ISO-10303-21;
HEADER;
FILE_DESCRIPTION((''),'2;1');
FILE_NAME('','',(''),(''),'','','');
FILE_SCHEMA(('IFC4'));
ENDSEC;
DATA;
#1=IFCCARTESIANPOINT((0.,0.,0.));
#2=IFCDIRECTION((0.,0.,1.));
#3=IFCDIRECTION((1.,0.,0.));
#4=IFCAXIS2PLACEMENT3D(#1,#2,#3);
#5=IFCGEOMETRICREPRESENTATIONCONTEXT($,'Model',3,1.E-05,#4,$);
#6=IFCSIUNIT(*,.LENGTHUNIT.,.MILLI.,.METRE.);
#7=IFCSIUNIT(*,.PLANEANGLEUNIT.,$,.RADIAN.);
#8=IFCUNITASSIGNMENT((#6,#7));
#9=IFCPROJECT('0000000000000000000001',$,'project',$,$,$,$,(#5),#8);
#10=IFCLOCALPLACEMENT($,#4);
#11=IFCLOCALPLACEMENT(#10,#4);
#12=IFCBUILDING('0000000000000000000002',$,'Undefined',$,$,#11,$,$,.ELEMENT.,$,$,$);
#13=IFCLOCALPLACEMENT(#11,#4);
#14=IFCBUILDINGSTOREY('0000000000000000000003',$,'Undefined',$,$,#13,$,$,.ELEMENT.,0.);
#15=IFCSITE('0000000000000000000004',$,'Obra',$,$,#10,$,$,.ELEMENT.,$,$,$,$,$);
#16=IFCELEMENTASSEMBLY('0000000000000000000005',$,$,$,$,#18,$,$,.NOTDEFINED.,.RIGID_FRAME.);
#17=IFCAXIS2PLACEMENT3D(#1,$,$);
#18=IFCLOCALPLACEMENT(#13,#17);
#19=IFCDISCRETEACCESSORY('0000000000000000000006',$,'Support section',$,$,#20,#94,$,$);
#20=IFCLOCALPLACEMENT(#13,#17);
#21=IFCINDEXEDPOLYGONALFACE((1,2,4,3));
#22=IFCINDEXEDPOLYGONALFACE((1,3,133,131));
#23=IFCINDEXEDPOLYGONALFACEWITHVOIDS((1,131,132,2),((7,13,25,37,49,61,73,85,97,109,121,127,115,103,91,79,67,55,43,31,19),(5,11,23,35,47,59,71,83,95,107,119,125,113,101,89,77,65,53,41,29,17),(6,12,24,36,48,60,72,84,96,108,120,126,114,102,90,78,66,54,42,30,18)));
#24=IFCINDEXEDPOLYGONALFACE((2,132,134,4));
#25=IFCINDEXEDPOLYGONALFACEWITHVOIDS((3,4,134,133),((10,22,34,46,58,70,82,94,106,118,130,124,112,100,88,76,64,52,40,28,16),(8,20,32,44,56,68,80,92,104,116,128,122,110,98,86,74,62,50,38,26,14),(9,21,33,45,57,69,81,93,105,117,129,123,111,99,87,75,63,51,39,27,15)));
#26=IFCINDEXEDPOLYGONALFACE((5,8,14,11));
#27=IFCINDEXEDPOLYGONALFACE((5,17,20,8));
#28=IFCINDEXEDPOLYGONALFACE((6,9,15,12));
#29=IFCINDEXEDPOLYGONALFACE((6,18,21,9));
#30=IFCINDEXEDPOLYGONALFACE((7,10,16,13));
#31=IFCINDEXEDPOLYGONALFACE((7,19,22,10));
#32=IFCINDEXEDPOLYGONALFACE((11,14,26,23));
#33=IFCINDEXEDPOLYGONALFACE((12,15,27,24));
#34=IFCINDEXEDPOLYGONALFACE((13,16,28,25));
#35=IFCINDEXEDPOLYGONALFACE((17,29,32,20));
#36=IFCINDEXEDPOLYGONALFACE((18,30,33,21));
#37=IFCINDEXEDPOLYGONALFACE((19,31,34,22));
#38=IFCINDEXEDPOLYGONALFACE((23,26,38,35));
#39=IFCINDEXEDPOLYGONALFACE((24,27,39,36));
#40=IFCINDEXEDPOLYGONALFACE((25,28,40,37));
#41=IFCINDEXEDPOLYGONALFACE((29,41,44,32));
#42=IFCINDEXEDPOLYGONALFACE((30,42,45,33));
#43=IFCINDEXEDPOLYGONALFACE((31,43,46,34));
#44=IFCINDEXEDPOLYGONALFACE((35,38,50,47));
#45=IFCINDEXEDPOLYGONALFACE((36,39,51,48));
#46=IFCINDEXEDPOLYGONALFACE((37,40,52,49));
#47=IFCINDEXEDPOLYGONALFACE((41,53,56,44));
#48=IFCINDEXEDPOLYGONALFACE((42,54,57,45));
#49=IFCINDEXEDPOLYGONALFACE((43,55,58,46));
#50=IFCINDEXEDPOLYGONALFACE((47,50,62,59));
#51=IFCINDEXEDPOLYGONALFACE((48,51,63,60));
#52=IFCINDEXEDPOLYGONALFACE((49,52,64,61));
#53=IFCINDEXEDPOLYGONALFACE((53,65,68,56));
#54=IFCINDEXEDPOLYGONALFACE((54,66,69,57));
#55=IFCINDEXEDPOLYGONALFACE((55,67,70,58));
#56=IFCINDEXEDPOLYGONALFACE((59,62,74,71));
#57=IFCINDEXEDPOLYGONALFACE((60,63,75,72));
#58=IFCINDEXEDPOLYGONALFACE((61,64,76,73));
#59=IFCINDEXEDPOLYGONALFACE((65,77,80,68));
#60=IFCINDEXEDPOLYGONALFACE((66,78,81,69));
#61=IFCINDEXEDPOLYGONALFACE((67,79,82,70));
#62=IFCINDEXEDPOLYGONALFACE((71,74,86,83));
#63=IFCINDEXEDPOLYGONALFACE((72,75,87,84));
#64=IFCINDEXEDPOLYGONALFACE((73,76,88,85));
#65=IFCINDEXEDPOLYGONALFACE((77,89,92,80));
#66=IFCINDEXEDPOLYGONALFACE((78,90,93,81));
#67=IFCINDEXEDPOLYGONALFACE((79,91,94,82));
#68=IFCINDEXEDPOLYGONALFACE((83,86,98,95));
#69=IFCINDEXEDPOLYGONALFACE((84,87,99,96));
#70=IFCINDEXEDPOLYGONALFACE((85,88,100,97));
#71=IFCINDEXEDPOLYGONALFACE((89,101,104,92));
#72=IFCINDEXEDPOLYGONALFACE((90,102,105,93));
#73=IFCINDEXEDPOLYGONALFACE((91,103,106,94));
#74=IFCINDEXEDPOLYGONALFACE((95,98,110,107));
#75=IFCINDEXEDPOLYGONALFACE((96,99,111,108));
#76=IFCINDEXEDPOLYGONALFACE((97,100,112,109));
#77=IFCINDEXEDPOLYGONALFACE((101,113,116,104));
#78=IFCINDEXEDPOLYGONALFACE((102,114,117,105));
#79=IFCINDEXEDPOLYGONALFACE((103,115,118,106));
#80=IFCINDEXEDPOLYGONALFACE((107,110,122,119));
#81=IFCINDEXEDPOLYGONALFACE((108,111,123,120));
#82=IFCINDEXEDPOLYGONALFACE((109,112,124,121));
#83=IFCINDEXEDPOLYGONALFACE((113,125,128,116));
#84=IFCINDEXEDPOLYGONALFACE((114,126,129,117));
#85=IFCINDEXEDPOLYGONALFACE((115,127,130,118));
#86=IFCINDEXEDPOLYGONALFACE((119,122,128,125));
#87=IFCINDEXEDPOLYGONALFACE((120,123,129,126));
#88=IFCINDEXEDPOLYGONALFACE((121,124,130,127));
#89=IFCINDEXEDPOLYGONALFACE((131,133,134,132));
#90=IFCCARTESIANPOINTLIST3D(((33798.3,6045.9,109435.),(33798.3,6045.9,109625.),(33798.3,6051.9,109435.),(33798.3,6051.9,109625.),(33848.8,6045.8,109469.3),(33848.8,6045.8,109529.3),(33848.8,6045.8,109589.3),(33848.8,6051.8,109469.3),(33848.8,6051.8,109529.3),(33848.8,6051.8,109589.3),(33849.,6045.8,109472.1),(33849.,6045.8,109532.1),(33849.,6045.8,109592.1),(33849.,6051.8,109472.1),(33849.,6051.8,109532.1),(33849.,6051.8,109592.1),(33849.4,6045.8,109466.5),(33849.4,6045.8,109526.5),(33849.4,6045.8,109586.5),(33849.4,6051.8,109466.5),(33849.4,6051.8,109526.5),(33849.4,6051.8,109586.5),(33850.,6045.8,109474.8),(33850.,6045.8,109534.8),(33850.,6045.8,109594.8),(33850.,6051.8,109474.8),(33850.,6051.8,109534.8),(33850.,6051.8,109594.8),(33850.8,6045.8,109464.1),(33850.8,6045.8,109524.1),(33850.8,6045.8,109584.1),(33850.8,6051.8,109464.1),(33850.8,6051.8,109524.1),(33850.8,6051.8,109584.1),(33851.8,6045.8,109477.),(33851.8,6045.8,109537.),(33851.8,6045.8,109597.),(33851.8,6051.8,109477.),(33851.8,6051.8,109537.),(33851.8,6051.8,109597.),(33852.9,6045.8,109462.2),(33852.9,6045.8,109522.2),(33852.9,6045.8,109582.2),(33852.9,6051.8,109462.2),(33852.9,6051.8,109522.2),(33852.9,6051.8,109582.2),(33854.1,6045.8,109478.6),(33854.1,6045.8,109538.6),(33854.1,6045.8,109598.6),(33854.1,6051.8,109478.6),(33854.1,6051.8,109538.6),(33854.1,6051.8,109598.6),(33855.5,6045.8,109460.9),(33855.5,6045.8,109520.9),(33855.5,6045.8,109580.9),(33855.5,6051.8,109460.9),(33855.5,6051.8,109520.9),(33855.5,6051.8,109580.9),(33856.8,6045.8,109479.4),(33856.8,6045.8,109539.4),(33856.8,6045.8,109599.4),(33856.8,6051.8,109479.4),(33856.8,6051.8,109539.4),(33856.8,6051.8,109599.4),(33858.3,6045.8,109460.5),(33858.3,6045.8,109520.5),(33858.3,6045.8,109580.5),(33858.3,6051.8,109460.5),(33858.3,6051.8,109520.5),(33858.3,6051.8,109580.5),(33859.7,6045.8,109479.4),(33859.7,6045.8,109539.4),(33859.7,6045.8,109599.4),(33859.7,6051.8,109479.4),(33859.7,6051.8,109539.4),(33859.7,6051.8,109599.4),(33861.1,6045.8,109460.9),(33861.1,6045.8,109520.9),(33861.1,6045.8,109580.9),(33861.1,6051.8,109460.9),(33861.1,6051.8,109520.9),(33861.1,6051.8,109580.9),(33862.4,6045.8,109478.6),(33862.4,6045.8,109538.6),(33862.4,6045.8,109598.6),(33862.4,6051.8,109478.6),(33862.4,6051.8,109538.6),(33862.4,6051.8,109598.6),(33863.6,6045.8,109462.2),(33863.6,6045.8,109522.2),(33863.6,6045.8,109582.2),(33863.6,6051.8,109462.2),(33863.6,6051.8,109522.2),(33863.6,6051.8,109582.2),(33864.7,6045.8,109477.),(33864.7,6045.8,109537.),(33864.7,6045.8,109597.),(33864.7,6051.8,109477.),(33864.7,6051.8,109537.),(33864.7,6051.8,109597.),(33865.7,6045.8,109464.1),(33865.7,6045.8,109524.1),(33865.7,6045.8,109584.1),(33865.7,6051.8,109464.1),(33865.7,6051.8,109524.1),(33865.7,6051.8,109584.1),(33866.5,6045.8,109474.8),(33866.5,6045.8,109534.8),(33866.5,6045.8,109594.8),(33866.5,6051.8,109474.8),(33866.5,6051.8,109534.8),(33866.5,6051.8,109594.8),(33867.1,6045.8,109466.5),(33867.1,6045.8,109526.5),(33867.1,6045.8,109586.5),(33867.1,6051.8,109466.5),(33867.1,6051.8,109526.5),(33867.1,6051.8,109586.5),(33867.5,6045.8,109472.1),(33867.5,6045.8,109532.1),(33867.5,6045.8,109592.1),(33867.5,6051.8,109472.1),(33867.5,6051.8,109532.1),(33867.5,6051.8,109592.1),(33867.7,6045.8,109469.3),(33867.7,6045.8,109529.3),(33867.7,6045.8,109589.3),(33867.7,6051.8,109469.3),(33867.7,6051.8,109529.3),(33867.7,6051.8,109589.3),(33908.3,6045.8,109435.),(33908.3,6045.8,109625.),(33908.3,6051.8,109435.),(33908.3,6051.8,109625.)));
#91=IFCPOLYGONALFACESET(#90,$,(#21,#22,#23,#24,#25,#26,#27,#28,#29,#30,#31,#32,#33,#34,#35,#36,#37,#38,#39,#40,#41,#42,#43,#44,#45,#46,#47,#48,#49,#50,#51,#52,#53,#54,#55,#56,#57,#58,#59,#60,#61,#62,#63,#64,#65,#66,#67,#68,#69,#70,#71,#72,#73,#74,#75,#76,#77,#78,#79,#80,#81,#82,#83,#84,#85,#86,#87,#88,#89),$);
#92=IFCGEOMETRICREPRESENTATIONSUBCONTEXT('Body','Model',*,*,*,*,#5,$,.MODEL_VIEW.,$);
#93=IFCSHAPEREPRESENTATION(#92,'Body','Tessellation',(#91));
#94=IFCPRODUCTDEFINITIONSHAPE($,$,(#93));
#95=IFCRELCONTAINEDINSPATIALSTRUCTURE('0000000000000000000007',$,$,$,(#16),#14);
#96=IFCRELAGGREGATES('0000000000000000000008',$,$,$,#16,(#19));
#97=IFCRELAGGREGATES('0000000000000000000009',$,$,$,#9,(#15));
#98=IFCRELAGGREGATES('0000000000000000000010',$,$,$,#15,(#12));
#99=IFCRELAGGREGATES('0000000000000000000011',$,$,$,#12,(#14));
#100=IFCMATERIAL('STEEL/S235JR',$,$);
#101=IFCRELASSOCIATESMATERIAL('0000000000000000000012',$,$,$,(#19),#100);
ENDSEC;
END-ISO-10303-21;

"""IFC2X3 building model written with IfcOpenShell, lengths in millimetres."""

from ifc_helpers import new_model, si_unit, frame, origin_with_axes, origin_2d_with_axis, place, context, subcontext, project, spatial, rectangle, circle, extrude, source, transform, mapped, material, element, aggregate, save


model = new_model("IFC2X3")

# Units and contexts
model_context = context("Model", 3, precision=1e-05, world=origin_with_axes())
body_context = subcontext(model_context, "Body", "Model", "MODEL_VIEW")
ifc_project = project(units=[si_unit("LENGTHUNIT", "METRE", prefix="MILLI"), si_unit("PLANEANGLEUNIT", "RADIAN")], contexts=[model_context])

# Site, building, storey
site_placement = place(None, origin_with_axes())
site = spatial("IfcSite", under=ifc_project, at=site_placement, Name="Obra", CompositionType="ELEMENT")
building_placement = place(site_placement, origin_with_axes())
building = spatial("IfcBuilding", under=site, at=building_placement, Name="Undefined", CompositionType="ELEMENT")
storey_placement = place(building_placement, origin_with_axes())
storey = spatial("IfcBuildingStorey", under=building, at=storey_placement, Name="Undefined", CompositionType="ELEMENT", Elevation=0.0)

# Shared definitions
ifc_material_1 = material(Name="STEEL/S235JR")

# Element assembly, discrete accessory, opening
shared_shape_1 = source(origin_with_axes(), body_context, "Body", "SweptSolid", [
    extrude(circle(Radius=9.5, at=origin_2d_with_axis()), frame((0.0, -9.2, 0.0), z_axis=(0.0, 1.0, 0.0), x_axis=(1.0, 0.0, 0.0)), (0.0, 0.0, 1.0), 6.2),
])
assembly_1_placement = place(storey_placement, origin_with_axes())
assembly_1 = element("IfcElementAssembly", 1, at=assembly_1_placement, inside=storey, AssemblyPlace="NOTDEFINED", PredefinedType="RIGID_FRAME")
discrete_accessory_1_placement = place(assembly_1_placement, frame((33853.3, 6048.8, 109435.0), z_axis=(0.0, 0.0, 1.0), x_axis=(-1.0, 0.000126, 0.0)))
discrete_accessory_1 = element("IfcDiscreteAccessory", 2, at=discrete_accessory_1_placement, material=ifc_material_1, Name="Support section", context=body_context, shape_type="SweptSolid", body=[
    extrude(rectangle(XDim=6.0, YDim=110.0, at=origin_2d_with_axis()), frame((0.0, 0.0, 190.0), z_axis=(0.0, 0.0, -1.0), x_axis=(0.0, 1.0, 0.0)), (0.0, 0.0, 1.0), 190.0),
])
opening_1_placement = place(assembly_1_placement, frame((33808.3, 6055.0, 109650.0), z_axis=(1.0, -0.000126, 0.0), x_axis=(0.0, 0.0, -1.0)))
element("IfcOpeningElement", 3, at=opening_1_placement, cuts=discrete_accessory_1, ObjectType="Opening", context=body_context, shape_type="MappedRepresentation", body=[
    mapped(shared_shape_1, transform((60.0, 0.0, 50.0))),
    mapped(shared_shape_1, transform((120.0, 0.0, 50.0))),
    mapped(shared_shape_1, transform((180.0, 0.0, 50.0))),
])
aggregate(assembly_1, [discrete_accessory_1])

save(model, "model.ifc")
